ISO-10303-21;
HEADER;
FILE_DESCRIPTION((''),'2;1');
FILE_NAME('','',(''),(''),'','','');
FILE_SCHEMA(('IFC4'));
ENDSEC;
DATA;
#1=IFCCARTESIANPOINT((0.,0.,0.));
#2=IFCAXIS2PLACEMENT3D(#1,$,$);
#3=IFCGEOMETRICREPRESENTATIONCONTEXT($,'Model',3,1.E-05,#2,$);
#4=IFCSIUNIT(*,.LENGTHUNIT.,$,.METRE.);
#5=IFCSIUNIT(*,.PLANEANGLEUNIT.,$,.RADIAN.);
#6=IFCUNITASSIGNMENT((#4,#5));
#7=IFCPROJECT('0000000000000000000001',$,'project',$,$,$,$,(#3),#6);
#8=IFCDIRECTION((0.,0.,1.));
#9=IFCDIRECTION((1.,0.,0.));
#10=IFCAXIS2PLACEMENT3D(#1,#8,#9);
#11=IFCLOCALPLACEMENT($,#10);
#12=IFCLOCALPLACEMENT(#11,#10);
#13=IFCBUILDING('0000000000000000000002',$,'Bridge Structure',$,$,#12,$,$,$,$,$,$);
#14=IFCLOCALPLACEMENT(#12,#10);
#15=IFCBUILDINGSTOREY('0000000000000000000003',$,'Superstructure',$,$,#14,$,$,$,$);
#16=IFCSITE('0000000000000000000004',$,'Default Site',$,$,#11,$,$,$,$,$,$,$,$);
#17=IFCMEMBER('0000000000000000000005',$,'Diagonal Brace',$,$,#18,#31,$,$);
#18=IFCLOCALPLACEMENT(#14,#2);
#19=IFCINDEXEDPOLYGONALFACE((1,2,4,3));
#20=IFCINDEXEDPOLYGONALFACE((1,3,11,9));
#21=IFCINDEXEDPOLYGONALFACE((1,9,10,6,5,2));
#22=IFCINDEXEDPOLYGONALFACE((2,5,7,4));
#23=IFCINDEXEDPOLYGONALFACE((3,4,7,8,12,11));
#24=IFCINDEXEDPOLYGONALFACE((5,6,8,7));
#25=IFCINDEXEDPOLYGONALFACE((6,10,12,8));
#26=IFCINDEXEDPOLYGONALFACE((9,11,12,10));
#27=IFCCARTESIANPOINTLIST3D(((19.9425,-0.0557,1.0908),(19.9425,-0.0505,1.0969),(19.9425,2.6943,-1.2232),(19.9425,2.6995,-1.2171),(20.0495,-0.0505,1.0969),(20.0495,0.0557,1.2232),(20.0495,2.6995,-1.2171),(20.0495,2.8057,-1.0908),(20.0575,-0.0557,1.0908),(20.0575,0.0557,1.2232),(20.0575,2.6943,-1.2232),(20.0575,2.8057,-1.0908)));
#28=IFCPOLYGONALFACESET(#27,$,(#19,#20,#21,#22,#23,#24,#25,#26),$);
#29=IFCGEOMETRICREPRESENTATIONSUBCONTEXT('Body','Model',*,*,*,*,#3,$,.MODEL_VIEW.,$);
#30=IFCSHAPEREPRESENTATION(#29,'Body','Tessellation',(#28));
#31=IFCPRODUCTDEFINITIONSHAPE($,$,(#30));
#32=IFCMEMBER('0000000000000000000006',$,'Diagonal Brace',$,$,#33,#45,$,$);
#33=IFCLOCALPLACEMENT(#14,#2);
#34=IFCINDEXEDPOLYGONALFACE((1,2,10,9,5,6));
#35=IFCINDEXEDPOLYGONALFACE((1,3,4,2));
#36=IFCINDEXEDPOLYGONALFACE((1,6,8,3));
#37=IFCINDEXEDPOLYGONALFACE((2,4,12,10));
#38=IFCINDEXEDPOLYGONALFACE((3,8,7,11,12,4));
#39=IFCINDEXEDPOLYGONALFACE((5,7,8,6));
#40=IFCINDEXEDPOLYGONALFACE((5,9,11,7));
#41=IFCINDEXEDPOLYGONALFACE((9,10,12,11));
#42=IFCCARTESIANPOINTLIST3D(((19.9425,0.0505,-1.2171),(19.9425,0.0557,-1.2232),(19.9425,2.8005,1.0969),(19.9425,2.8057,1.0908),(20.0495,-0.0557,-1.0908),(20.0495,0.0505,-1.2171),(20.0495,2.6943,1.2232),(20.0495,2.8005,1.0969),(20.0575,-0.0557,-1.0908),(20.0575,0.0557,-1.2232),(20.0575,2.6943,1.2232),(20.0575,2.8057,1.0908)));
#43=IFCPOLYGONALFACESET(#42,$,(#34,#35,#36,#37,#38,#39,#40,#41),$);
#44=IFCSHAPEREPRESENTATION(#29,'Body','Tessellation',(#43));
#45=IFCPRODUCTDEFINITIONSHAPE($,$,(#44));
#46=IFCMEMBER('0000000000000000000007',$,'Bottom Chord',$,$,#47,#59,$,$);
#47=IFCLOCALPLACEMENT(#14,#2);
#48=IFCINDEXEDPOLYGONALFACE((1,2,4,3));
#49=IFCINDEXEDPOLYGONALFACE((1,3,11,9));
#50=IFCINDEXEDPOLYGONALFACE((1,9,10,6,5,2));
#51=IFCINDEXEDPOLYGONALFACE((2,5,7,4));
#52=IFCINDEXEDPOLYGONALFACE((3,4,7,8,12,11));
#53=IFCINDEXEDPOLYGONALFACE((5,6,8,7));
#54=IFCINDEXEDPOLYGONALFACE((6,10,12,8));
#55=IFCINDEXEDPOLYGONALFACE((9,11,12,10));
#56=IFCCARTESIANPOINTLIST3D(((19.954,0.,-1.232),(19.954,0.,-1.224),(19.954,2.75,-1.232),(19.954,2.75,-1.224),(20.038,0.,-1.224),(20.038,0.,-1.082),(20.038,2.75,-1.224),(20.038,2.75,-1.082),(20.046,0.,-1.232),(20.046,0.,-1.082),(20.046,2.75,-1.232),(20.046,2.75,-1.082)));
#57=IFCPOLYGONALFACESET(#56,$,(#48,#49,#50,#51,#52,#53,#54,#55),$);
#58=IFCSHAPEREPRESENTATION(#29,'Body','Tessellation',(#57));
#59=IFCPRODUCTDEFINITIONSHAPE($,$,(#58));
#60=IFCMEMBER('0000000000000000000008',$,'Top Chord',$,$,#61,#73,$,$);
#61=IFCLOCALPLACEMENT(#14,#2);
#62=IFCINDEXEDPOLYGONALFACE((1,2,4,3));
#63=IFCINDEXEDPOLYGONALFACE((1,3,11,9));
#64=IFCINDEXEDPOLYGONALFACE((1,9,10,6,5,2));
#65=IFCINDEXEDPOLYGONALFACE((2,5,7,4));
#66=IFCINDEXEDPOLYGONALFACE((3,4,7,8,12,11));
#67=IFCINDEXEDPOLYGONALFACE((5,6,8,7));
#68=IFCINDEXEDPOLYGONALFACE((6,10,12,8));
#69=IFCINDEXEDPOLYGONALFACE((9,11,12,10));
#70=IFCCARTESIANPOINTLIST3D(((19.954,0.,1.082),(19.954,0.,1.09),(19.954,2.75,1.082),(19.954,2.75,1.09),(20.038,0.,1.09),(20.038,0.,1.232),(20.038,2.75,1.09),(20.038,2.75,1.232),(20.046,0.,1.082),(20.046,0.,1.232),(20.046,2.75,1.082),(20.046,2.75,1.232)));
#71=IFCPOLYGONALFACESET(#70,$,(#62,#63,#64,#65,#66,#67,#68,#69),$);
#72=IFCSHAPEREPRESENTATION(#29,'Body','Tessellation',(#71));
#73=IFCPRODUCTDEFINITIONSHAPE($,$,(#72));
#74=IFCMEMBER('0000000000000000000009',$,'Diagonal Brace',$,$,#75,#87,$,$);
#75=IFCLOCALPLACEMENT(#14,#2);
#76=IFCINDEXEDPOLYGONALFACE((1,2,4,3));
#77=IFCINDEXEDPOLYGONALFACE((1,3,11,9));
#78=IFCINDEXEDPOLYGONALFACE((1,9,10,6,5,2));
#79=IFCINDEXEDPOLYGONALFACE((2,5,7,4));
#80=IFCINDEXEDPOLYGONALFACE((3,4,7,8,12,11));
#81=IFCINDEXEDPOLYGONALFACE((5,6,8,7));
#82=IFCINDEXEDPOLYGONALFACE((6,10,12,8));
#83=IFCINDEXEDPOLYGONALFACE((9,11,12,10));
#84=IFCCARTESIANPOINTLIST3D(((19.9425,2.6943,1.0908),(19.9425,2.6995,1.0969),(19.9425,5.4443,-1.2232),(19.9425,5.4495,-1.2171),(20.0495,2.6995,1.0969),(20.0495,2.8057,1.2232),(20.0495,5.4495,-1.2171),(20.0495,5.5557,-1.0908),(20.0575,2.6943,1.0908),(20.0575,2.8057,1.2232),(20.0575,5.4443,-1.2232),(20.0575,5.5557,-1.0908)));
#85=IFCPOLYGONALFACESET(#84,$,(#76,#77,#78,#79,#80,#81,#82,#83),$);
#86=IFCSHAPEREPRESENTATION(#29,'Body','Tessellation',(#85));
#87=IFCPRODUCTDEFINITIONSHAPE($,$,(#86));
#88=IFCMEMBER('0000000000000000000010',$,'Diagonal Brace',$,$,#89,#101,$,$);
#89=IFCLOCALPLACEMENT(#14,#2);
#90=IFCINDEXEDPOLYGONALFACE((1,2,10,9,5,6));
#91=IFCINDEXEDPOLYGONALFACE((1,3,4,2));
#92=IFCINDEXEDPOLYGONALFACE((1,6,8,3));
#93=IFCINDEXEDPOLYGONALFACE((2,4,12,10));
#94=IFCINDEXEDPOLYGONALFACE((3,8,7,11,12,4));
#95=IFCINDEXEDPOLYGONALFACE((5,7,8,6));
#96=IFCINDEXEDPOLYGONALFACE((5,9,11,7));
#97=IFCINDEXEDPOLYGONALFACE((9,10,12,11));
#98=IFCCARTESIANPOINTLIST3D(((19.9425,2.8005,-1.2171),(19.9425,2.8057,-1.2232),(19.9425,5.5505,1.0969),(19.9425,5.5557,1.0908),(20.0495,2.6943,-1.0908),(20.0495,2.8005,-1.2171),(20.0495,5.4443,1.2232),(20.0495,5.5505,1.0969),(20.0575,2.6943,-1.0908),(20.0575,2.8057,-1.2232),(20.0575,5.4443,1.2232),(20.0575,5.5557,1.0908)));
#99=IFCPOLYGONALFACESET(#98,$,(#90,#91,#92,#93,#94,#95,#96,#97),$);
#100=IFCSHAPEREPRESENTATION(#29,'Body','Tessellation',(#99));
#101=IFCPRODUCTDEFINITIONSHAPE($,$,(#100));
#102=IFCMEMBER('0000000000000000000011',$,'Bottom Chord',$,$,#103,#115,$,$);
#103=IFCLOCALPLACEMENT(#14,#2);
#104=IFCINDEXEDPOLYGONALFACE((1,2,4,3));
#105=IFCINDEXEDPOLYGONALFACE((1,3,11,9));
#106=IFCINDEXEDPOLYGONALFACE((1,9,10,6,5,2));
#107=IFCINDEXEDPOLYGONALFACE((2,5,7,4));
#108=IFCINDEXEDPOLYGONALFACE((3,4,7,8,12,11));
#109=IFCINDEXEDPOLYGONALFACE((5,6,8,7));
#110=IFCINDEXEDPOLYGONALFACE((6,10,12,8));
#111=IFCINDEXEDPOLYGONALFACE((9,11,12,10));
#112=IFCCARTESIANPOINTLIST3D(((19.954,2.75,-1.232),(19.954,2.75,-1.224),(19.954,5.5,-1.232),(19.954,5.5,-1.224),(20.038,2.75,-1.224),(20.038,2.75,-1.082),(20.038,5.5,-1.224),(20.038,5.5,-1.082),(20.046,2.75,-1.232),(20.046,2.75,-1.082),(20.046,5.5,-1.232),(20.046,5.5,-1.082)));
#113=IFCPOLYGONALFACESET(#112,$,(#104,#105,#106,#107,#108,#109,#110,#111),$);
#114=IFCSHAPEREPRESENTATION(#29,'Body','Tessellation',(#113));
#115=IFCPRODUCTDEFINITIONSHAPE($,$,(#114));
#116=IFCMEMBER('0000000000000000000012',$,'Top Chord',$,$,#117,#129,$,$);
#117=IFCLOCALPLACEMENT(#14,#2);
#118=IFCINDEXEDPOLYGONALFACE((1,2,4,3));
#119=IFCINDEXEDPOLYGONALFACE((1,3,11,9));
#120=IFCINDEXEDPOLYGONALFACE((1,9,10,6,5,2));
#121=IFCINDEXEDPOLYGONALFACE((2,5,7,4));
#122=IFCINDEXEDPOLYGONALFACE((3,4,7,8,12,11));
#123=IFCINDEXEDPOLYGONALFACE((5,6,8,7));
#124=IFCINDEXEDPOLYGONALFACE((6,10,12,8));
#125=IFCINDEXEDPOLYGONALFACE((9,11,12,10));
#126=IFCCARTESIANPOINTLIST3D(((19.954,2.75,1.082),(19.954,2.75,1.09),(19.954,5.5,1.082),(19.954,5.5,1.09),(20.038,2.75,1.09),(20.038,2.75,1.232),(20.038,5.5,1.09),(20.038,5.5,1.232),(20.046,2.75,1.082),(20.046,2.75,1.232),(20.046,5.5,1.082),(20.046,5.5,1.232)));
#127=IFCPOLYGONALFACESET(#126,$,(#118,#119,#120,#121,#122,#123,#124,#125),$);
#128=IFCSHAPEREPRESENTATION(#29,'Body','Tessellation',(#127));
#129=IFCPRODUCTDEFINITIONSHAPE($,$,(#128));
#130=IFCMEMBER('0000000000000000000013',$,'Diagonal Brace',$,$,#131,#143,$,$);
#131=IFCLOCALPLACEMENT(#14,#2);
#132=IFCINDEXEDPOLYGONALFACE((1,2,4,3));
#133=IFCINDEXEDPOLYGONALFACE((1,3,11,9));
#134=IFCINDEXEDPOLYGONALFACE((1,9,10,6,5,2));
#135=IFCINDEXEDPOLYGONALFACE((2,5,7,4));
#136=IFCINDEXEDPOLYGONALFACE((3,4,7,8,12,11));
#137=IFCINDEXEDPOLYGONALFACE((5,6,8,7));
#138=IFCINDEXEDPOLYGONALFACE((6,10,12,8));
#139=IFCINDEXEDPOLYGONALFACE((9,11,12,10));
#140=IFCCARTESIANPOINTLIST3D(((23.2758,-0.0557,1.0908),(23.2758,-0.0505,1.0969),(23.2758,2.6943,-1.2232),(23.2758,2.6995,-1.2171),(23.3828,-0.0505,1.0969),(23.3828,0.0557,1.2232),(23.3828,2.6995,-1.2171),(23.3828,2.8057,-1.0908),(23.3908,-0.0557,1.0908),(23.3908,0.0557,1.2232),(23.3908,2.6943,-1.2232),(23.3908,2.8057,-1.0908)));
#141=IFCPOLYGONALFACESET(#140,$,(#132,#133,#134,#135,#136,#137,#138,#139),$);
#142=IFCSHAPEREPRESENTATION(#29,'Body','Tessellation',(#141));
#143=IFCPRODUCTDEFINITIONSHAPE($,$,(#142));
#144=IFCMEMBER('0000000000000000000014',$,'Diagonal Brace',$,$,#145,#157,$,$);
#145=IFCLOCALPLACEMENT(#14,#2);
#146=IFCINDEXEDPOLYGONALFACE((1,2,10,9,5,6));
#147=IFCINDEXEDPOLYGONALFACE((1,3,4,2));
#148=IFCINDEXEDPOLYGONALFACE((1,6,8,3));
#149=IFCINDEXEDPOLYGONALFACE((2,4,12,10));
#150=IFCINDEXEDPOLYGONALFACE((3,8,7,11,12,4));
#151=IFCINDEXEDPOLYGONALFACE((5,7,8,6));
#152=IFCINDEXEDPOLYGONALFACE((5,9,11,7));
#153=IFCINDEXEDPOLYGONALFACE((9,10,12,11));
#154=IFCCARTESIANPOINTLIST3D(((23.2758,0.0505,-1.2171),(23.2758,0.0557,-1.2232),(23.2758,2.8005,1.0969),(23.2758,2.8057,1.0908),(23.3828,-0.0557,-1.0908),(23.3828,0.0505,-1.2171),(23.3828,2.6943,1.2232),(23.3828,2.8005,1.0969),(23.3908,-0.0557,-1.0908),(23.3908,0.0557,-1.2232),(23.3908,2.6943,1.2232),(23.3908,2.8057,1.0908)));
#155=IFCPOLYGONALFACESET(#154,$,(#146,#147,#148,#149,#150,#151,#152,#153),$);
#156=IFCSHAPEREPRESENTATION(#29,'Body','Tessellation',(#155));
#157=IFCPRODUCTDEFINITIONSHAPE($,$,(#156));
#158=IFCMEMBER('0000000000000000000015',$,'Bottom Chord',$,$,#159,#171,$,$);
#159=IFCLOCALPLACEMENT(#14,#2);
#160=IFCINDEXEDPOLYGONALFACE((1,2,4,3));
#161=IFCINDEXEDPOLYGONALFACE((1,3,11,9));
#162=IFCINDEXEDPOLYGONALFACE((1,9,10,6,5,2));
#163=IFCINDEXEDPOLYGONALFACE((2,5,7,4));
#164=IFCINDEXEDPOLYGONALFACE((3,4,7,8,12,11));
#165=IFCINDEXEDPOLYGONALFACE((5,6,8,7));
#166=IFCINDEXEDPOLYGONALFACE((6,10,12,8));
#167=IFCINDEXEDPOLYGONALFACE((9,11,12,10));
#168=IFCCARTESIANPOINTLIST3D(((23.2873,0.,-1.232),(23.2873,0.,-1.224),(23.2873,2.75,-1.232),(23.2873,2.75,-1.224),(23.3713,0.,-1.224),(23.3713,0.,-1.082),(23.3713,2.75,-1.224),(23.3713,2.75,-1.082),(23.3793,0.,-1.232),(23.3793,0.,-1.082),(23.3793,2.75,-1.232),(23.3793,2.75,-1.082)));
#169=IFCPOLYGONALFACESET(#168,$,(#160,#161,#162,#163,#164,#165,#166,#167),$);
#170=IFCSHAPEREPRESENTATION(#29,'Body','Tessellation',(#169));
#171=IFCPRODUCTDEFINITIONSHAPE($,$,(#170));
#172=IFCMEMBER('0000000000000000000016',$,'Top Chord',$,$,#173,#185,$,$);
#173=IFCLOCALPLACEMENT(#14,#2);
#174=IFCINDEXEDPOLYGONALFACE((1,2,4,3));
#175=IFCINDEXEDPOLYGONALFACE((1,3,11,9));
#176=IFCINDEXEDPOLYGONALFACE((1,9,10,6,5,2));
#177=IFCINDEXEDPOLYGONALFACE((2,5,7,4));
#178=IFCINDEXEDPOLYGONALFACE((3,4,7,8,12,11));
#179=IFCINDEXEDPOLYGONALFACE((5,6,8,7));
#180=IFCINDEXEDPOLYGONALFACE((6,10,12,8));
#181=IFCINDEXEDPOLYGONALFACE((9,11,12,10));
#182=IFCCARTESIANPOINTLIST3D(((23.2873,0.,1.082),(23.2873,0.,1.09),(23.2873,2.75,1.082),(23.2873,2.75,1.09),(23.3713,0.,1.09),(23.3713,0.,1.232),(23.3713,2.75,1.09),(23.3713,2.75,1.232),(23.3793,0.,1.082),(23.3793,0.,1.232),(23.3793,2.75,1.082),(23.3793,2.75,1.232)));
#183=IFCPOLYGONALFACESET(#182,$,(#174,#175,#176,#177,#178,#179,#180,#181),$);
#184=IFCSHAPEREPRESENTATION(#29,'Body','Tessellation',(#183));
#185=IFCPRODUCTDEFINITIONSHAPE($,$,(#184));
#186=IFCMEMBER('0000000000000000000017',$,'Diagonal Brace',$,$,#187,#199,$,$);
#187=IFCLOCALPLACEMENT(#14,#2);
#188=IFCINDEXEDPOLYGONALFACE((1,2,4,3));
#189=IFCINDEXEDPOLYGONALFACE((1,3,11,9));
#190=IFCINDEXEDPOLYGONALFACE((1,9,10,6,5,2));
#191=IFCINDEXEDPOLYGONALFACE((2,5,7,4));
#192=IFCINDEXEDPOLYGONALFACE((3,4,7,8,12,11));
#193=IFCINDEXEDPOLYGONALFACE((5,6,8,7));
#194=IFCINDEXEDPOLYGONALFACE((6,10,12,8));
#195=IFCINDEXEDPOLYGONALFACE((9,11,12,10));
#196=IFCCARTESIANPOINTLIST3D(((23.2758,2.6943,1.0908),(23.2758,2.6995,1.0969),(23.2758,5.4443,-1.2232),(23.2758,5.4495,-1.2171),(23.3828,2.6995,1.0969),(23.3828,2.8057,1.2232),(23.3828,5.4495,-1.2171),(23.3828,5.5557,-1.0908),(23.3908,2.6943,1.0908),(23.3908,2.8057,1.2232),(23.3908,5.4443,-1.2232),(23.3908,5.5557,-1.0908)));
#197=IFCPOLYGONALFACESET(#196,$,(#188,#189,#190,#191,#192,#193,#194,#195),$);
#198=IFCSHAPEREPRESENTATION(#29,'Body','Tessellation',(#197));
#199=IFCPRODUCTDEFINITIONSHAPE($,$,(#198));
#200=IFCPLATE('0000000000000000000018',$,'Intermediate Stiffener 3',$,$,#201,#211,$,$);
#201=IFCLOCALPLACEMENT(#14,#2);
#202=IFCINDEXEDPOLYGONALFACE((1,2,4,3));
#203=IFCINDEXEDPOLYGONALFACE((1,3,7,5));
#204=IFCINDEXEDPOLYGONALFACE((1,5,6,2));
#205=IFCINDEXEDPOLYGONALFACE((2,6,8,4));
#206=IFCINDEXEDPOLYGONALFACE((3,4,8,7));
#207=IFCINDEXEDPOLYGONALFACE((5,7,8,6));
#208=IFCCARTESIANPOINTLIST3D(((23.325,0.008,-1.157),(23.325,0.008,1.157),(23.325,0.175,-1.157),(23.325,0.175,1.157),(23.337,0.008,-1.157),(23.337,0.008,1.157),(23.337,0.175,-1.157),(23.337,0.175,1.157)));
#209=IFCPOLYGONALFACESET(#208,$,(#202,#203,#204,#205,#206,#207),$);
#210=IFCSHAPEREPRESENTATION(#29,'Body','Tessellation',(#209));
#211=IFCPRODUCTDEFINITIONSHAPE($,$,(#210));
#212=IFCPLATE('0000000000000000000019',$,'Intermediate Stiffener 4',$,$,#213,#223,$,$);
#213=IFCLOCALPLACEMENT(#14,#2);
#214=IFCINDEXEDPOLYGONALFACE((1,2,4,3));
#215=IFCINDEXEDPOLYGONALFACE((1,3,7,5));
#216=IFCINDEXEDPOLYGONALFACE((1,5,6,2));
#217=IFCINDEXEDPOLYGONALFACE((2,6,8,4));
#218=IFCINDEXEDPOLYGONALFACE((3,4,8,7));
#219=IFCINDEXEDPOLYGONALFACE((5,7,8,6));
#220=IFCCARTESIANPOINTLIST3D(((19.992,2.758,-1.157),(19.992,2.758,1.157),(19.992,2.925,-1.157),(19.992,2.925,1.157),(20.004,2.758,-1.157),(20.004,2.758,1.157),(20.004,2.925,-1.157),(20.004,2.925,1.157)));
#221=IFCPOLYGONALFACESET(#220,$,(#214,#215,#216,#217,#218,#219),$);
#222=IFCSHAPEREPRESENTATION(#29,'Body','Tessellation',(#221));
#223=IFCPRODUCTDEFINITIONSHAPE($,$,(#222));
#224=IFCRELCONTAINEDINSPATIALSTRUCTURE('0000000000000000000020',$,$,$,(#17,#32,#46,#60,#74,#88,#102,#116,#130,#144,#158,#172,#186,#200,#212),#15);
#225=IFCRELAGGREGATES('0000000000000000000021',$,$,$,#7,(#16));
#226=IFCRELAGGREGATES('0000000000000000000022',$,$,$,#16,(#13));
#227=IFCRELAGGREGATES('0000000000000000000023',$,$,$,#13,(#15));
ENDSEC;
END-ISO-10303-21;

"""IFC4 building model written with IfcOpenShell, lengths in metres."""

from ifc_helpers import new_model, si_unit, frame, origin, origin_with_axes, origin_2d_with_axis, place, context, subcontext, project, spatial, rectangle, l_section, extrude, element, save


model = new_model("IFC4")

# Units and contexts
model_context = context("Model", 3, precision=1e-05, world=origin())
body_context = subcontext(model_context, "Body", "Model", "MODEL_VIEW")
ifc_project = project(units=[si_unit("LENGTHUNIT", "METRE"), si_unit("PLANEANGLEUNIT", "RADIAN")], contexts=[model_context])

# Site, building, storey
site_placement = place(None, origin_with_axes())
site = spatial("IfcSite", under=ifc_project, at=site_placement, Name="Default Site")
building_placement = place(site_placement, origin_with_axes())
building = spatial("IfcBuilding", under=site, at=building_placement, Name="Bridge Structure")
storey_placement = place(building_placement, origin_with_axes())
storey = spatial("IfcBuildingStorey", under=building, at=storey_placement, Name="Superstructure")

# Members
for number, where, z_axis, x_axis, name in (
    (1, (20.0, 0.0, 1.157), (0.0, 0.765156, -0.643844), (-1.0, 0.0, 0.0), "Diagonal Brace"),
    (2, (20.0, 0.0, -1.157), (0.0, 0.765156, 0.643844), (-1.0, 0.0, 0.0), "Diagonal Brace"),
):
    element("IfcMember", number, at=place(storey_placement, frame(where, z_axis=z_axis, x_axis=x_axis)), inside=storey, Name=name, context=body_context, shape_type="SweptSolid", body=[
        extrude(l_section(Depth=0.173, Width=0.115, Thickness=0.008, at=origin_2d_with_axis()), origin_with_axes(), (0.0, 0.0, 1.0), 3.594),
    ])
for number, where, z_axis, x_axis, name in (
    (3, (20.0, 0.0, -1.157), (0.0, 1.0, 0.0), (-1.0, 0.0, 0.0), "Bottom Chord"),
    (4, (20.0, 0.0, 1.157), (0.0, 1.0, 0.0), (-1.0, 0.0, 0.0), "Top Chord"),
):
    element("IfcMember", number, at=place(storey_placement, frame(where, z_axis=z_axis, x_axis=x_axis)), inside=storey, Name=name, context=body_context, shape_type="SweptSolid", body=[
        extrude(l_section(Depth=0.15, Width=0.092, Thickness=0.008, at=origin_2d_with_axis()), origin_with_axes(), (0.0, 0.0, 1.0), 2.75),
    ])
for number, where, z_axis, x_axis, name in (
    (5, (20.0, 2.75, 1.157), (0.0, 0.765156, -0.643844), (-1.0, 0.0, 0.0), "Diagonal Brace"),
    (6, (20.0, 2.75, -1.157), (0.0, 0.765156, 0.643844), (-1.0, 0.0, 0.0), "Diagonal Brace"),
):
    element("IfcMember", number, at=place(storey_placement, frame(where, z_axis=z_axis, x_axis=x_axis)), inside=storey, Name=name, context=body_context, shape_type="SweptSolid", body=[
        extrude(l_section(Depth=0.173, Width=0.115, Thickness=0.008, at=origin_2d_with_axis()), origin_with_axes(), (0.0, 0.0, 1.0), 3.594),
    ])
for number, where, z_axis, x_axis, name in (
    (7, (20.0, 2.75, -1.157), (0.0, 1.0, 0.0), (-1.0, 0.0, 0.0), "Bottom Chord"),
    (8, (20.0, 2.75, 1.157), (0.0, 1.0, 0.0), (-1.0, 0.0, 0.0), "Top Chord"),
):
    element("IfcMember", number, at=place(storey_placement, frame(where, z_axis=z_axis, x_axis=x_axis)), inside=storey, Name=name, context=body_context, shape_type="SweptSolid", body=[
        extrude(l_section(Depth=0.15, Width=0.092, Thickness=0.008, at=origin_2d_with_axis()), origin_with_axes(), (0.0, 0.0, 1.0), 2.75),
    ])
for number, where, z_axis, x_axis, name in (
    (9, (23.3333, 0.0, 1.157), (0.0, 0.765156, -0.643844), (-1.0, 0.0, 0.0), "Diagonal Brace"),
    (10, (23.3333, 0.0, -1.157), (0.0, 0.765156, 0.643844), (-1.0, 0.0, 0.0), "Diagonal Brace"),
):
    element("IfcMember", number, at=place(storey_placement, frame(where, z_axis=z_axis, x_axis=x_axis)), inside=storey, Name=name, context=body_context, shape_type="SweptSolid", body=[
        extrude(l_section(Depth=0.173, Width=0.115, Thickness=0.008, at=origin_2d_with_axis()), origin_with_axes(), (0.0, 0.0, 1.0), 3.594),
    ])
for number, where, z_axis, x_axis, name in (
    (11, (23.3333, 0.0, -1.157), (0.0, 1.0, 0.0), (-1.0, 0.0, 0.0), "Bottom Chord"),
    (12, (23.3333, 0.0, 1.157), (0.0, 1.0, 0.0), (-1.0, 0.0, 0.0), "Top Chord"),
):
    element("IfcMember", number, at=place(storey_placement, frame(where, z_axis=z_axis, x_axis=x_axis)), inside=storey, Name=name, context=body_context, shape_type="SweptSolid", body=[
        extrude(l_section(Depth=0.15, Width=0.092, Thickness=0.008, at=origin_2d_with_axis()), origin_with_axes(), (0.0, 0.0, 1.0), 2.75),
    ])
member_placement = place(storey_placement, frame((23.3333, 2.75, 1.157), z_axis=(0.0, 0.765156, -0.643844), x_axis=(-1.0, 0.0, 0.0)))
element("IfcMember", 13, at=member_placement, inside=storey, Name="Diagonal Brace", context=body_context, shape_type="SweptSolid", body=[
    extrude(l_section(Depth=0.173, Width=0.115, Thickness=0.008, at=origin_2d_with_axis()), origin_with_axes(), (0.0, 0.0, 1.0), 3.594),
])

# Plates
for number, where, z_axis, x_axis, name in (
    (14, (23.331, 0.0915, -1.157), (0.0, 0.0, 1.0), (1.0, 0.0, 0.0), "Intermediate Stiffener 3"),
    (15, (19.998, 2.8415, -1.157), (0.0, 0.0, 1.0), (1.0, 0.0, 0.0), "Intermediate Stiffener 4"),
):
    element("IfcPlate", number, at=place(storey_placement, frame(where, z_axis=z_axis, x_axis=x_axis)), inside=storey, Name=name, context=body_context, shape_type="SweptSolid", body=[
        extrude(rectangle(XDim=0.012, YDim=0.167, at=origin_2d_with_axis()), origin_with_axes(), (0.0, 0.0, 1.0), 2.314),
    ])

save(model, "model.ifc")
